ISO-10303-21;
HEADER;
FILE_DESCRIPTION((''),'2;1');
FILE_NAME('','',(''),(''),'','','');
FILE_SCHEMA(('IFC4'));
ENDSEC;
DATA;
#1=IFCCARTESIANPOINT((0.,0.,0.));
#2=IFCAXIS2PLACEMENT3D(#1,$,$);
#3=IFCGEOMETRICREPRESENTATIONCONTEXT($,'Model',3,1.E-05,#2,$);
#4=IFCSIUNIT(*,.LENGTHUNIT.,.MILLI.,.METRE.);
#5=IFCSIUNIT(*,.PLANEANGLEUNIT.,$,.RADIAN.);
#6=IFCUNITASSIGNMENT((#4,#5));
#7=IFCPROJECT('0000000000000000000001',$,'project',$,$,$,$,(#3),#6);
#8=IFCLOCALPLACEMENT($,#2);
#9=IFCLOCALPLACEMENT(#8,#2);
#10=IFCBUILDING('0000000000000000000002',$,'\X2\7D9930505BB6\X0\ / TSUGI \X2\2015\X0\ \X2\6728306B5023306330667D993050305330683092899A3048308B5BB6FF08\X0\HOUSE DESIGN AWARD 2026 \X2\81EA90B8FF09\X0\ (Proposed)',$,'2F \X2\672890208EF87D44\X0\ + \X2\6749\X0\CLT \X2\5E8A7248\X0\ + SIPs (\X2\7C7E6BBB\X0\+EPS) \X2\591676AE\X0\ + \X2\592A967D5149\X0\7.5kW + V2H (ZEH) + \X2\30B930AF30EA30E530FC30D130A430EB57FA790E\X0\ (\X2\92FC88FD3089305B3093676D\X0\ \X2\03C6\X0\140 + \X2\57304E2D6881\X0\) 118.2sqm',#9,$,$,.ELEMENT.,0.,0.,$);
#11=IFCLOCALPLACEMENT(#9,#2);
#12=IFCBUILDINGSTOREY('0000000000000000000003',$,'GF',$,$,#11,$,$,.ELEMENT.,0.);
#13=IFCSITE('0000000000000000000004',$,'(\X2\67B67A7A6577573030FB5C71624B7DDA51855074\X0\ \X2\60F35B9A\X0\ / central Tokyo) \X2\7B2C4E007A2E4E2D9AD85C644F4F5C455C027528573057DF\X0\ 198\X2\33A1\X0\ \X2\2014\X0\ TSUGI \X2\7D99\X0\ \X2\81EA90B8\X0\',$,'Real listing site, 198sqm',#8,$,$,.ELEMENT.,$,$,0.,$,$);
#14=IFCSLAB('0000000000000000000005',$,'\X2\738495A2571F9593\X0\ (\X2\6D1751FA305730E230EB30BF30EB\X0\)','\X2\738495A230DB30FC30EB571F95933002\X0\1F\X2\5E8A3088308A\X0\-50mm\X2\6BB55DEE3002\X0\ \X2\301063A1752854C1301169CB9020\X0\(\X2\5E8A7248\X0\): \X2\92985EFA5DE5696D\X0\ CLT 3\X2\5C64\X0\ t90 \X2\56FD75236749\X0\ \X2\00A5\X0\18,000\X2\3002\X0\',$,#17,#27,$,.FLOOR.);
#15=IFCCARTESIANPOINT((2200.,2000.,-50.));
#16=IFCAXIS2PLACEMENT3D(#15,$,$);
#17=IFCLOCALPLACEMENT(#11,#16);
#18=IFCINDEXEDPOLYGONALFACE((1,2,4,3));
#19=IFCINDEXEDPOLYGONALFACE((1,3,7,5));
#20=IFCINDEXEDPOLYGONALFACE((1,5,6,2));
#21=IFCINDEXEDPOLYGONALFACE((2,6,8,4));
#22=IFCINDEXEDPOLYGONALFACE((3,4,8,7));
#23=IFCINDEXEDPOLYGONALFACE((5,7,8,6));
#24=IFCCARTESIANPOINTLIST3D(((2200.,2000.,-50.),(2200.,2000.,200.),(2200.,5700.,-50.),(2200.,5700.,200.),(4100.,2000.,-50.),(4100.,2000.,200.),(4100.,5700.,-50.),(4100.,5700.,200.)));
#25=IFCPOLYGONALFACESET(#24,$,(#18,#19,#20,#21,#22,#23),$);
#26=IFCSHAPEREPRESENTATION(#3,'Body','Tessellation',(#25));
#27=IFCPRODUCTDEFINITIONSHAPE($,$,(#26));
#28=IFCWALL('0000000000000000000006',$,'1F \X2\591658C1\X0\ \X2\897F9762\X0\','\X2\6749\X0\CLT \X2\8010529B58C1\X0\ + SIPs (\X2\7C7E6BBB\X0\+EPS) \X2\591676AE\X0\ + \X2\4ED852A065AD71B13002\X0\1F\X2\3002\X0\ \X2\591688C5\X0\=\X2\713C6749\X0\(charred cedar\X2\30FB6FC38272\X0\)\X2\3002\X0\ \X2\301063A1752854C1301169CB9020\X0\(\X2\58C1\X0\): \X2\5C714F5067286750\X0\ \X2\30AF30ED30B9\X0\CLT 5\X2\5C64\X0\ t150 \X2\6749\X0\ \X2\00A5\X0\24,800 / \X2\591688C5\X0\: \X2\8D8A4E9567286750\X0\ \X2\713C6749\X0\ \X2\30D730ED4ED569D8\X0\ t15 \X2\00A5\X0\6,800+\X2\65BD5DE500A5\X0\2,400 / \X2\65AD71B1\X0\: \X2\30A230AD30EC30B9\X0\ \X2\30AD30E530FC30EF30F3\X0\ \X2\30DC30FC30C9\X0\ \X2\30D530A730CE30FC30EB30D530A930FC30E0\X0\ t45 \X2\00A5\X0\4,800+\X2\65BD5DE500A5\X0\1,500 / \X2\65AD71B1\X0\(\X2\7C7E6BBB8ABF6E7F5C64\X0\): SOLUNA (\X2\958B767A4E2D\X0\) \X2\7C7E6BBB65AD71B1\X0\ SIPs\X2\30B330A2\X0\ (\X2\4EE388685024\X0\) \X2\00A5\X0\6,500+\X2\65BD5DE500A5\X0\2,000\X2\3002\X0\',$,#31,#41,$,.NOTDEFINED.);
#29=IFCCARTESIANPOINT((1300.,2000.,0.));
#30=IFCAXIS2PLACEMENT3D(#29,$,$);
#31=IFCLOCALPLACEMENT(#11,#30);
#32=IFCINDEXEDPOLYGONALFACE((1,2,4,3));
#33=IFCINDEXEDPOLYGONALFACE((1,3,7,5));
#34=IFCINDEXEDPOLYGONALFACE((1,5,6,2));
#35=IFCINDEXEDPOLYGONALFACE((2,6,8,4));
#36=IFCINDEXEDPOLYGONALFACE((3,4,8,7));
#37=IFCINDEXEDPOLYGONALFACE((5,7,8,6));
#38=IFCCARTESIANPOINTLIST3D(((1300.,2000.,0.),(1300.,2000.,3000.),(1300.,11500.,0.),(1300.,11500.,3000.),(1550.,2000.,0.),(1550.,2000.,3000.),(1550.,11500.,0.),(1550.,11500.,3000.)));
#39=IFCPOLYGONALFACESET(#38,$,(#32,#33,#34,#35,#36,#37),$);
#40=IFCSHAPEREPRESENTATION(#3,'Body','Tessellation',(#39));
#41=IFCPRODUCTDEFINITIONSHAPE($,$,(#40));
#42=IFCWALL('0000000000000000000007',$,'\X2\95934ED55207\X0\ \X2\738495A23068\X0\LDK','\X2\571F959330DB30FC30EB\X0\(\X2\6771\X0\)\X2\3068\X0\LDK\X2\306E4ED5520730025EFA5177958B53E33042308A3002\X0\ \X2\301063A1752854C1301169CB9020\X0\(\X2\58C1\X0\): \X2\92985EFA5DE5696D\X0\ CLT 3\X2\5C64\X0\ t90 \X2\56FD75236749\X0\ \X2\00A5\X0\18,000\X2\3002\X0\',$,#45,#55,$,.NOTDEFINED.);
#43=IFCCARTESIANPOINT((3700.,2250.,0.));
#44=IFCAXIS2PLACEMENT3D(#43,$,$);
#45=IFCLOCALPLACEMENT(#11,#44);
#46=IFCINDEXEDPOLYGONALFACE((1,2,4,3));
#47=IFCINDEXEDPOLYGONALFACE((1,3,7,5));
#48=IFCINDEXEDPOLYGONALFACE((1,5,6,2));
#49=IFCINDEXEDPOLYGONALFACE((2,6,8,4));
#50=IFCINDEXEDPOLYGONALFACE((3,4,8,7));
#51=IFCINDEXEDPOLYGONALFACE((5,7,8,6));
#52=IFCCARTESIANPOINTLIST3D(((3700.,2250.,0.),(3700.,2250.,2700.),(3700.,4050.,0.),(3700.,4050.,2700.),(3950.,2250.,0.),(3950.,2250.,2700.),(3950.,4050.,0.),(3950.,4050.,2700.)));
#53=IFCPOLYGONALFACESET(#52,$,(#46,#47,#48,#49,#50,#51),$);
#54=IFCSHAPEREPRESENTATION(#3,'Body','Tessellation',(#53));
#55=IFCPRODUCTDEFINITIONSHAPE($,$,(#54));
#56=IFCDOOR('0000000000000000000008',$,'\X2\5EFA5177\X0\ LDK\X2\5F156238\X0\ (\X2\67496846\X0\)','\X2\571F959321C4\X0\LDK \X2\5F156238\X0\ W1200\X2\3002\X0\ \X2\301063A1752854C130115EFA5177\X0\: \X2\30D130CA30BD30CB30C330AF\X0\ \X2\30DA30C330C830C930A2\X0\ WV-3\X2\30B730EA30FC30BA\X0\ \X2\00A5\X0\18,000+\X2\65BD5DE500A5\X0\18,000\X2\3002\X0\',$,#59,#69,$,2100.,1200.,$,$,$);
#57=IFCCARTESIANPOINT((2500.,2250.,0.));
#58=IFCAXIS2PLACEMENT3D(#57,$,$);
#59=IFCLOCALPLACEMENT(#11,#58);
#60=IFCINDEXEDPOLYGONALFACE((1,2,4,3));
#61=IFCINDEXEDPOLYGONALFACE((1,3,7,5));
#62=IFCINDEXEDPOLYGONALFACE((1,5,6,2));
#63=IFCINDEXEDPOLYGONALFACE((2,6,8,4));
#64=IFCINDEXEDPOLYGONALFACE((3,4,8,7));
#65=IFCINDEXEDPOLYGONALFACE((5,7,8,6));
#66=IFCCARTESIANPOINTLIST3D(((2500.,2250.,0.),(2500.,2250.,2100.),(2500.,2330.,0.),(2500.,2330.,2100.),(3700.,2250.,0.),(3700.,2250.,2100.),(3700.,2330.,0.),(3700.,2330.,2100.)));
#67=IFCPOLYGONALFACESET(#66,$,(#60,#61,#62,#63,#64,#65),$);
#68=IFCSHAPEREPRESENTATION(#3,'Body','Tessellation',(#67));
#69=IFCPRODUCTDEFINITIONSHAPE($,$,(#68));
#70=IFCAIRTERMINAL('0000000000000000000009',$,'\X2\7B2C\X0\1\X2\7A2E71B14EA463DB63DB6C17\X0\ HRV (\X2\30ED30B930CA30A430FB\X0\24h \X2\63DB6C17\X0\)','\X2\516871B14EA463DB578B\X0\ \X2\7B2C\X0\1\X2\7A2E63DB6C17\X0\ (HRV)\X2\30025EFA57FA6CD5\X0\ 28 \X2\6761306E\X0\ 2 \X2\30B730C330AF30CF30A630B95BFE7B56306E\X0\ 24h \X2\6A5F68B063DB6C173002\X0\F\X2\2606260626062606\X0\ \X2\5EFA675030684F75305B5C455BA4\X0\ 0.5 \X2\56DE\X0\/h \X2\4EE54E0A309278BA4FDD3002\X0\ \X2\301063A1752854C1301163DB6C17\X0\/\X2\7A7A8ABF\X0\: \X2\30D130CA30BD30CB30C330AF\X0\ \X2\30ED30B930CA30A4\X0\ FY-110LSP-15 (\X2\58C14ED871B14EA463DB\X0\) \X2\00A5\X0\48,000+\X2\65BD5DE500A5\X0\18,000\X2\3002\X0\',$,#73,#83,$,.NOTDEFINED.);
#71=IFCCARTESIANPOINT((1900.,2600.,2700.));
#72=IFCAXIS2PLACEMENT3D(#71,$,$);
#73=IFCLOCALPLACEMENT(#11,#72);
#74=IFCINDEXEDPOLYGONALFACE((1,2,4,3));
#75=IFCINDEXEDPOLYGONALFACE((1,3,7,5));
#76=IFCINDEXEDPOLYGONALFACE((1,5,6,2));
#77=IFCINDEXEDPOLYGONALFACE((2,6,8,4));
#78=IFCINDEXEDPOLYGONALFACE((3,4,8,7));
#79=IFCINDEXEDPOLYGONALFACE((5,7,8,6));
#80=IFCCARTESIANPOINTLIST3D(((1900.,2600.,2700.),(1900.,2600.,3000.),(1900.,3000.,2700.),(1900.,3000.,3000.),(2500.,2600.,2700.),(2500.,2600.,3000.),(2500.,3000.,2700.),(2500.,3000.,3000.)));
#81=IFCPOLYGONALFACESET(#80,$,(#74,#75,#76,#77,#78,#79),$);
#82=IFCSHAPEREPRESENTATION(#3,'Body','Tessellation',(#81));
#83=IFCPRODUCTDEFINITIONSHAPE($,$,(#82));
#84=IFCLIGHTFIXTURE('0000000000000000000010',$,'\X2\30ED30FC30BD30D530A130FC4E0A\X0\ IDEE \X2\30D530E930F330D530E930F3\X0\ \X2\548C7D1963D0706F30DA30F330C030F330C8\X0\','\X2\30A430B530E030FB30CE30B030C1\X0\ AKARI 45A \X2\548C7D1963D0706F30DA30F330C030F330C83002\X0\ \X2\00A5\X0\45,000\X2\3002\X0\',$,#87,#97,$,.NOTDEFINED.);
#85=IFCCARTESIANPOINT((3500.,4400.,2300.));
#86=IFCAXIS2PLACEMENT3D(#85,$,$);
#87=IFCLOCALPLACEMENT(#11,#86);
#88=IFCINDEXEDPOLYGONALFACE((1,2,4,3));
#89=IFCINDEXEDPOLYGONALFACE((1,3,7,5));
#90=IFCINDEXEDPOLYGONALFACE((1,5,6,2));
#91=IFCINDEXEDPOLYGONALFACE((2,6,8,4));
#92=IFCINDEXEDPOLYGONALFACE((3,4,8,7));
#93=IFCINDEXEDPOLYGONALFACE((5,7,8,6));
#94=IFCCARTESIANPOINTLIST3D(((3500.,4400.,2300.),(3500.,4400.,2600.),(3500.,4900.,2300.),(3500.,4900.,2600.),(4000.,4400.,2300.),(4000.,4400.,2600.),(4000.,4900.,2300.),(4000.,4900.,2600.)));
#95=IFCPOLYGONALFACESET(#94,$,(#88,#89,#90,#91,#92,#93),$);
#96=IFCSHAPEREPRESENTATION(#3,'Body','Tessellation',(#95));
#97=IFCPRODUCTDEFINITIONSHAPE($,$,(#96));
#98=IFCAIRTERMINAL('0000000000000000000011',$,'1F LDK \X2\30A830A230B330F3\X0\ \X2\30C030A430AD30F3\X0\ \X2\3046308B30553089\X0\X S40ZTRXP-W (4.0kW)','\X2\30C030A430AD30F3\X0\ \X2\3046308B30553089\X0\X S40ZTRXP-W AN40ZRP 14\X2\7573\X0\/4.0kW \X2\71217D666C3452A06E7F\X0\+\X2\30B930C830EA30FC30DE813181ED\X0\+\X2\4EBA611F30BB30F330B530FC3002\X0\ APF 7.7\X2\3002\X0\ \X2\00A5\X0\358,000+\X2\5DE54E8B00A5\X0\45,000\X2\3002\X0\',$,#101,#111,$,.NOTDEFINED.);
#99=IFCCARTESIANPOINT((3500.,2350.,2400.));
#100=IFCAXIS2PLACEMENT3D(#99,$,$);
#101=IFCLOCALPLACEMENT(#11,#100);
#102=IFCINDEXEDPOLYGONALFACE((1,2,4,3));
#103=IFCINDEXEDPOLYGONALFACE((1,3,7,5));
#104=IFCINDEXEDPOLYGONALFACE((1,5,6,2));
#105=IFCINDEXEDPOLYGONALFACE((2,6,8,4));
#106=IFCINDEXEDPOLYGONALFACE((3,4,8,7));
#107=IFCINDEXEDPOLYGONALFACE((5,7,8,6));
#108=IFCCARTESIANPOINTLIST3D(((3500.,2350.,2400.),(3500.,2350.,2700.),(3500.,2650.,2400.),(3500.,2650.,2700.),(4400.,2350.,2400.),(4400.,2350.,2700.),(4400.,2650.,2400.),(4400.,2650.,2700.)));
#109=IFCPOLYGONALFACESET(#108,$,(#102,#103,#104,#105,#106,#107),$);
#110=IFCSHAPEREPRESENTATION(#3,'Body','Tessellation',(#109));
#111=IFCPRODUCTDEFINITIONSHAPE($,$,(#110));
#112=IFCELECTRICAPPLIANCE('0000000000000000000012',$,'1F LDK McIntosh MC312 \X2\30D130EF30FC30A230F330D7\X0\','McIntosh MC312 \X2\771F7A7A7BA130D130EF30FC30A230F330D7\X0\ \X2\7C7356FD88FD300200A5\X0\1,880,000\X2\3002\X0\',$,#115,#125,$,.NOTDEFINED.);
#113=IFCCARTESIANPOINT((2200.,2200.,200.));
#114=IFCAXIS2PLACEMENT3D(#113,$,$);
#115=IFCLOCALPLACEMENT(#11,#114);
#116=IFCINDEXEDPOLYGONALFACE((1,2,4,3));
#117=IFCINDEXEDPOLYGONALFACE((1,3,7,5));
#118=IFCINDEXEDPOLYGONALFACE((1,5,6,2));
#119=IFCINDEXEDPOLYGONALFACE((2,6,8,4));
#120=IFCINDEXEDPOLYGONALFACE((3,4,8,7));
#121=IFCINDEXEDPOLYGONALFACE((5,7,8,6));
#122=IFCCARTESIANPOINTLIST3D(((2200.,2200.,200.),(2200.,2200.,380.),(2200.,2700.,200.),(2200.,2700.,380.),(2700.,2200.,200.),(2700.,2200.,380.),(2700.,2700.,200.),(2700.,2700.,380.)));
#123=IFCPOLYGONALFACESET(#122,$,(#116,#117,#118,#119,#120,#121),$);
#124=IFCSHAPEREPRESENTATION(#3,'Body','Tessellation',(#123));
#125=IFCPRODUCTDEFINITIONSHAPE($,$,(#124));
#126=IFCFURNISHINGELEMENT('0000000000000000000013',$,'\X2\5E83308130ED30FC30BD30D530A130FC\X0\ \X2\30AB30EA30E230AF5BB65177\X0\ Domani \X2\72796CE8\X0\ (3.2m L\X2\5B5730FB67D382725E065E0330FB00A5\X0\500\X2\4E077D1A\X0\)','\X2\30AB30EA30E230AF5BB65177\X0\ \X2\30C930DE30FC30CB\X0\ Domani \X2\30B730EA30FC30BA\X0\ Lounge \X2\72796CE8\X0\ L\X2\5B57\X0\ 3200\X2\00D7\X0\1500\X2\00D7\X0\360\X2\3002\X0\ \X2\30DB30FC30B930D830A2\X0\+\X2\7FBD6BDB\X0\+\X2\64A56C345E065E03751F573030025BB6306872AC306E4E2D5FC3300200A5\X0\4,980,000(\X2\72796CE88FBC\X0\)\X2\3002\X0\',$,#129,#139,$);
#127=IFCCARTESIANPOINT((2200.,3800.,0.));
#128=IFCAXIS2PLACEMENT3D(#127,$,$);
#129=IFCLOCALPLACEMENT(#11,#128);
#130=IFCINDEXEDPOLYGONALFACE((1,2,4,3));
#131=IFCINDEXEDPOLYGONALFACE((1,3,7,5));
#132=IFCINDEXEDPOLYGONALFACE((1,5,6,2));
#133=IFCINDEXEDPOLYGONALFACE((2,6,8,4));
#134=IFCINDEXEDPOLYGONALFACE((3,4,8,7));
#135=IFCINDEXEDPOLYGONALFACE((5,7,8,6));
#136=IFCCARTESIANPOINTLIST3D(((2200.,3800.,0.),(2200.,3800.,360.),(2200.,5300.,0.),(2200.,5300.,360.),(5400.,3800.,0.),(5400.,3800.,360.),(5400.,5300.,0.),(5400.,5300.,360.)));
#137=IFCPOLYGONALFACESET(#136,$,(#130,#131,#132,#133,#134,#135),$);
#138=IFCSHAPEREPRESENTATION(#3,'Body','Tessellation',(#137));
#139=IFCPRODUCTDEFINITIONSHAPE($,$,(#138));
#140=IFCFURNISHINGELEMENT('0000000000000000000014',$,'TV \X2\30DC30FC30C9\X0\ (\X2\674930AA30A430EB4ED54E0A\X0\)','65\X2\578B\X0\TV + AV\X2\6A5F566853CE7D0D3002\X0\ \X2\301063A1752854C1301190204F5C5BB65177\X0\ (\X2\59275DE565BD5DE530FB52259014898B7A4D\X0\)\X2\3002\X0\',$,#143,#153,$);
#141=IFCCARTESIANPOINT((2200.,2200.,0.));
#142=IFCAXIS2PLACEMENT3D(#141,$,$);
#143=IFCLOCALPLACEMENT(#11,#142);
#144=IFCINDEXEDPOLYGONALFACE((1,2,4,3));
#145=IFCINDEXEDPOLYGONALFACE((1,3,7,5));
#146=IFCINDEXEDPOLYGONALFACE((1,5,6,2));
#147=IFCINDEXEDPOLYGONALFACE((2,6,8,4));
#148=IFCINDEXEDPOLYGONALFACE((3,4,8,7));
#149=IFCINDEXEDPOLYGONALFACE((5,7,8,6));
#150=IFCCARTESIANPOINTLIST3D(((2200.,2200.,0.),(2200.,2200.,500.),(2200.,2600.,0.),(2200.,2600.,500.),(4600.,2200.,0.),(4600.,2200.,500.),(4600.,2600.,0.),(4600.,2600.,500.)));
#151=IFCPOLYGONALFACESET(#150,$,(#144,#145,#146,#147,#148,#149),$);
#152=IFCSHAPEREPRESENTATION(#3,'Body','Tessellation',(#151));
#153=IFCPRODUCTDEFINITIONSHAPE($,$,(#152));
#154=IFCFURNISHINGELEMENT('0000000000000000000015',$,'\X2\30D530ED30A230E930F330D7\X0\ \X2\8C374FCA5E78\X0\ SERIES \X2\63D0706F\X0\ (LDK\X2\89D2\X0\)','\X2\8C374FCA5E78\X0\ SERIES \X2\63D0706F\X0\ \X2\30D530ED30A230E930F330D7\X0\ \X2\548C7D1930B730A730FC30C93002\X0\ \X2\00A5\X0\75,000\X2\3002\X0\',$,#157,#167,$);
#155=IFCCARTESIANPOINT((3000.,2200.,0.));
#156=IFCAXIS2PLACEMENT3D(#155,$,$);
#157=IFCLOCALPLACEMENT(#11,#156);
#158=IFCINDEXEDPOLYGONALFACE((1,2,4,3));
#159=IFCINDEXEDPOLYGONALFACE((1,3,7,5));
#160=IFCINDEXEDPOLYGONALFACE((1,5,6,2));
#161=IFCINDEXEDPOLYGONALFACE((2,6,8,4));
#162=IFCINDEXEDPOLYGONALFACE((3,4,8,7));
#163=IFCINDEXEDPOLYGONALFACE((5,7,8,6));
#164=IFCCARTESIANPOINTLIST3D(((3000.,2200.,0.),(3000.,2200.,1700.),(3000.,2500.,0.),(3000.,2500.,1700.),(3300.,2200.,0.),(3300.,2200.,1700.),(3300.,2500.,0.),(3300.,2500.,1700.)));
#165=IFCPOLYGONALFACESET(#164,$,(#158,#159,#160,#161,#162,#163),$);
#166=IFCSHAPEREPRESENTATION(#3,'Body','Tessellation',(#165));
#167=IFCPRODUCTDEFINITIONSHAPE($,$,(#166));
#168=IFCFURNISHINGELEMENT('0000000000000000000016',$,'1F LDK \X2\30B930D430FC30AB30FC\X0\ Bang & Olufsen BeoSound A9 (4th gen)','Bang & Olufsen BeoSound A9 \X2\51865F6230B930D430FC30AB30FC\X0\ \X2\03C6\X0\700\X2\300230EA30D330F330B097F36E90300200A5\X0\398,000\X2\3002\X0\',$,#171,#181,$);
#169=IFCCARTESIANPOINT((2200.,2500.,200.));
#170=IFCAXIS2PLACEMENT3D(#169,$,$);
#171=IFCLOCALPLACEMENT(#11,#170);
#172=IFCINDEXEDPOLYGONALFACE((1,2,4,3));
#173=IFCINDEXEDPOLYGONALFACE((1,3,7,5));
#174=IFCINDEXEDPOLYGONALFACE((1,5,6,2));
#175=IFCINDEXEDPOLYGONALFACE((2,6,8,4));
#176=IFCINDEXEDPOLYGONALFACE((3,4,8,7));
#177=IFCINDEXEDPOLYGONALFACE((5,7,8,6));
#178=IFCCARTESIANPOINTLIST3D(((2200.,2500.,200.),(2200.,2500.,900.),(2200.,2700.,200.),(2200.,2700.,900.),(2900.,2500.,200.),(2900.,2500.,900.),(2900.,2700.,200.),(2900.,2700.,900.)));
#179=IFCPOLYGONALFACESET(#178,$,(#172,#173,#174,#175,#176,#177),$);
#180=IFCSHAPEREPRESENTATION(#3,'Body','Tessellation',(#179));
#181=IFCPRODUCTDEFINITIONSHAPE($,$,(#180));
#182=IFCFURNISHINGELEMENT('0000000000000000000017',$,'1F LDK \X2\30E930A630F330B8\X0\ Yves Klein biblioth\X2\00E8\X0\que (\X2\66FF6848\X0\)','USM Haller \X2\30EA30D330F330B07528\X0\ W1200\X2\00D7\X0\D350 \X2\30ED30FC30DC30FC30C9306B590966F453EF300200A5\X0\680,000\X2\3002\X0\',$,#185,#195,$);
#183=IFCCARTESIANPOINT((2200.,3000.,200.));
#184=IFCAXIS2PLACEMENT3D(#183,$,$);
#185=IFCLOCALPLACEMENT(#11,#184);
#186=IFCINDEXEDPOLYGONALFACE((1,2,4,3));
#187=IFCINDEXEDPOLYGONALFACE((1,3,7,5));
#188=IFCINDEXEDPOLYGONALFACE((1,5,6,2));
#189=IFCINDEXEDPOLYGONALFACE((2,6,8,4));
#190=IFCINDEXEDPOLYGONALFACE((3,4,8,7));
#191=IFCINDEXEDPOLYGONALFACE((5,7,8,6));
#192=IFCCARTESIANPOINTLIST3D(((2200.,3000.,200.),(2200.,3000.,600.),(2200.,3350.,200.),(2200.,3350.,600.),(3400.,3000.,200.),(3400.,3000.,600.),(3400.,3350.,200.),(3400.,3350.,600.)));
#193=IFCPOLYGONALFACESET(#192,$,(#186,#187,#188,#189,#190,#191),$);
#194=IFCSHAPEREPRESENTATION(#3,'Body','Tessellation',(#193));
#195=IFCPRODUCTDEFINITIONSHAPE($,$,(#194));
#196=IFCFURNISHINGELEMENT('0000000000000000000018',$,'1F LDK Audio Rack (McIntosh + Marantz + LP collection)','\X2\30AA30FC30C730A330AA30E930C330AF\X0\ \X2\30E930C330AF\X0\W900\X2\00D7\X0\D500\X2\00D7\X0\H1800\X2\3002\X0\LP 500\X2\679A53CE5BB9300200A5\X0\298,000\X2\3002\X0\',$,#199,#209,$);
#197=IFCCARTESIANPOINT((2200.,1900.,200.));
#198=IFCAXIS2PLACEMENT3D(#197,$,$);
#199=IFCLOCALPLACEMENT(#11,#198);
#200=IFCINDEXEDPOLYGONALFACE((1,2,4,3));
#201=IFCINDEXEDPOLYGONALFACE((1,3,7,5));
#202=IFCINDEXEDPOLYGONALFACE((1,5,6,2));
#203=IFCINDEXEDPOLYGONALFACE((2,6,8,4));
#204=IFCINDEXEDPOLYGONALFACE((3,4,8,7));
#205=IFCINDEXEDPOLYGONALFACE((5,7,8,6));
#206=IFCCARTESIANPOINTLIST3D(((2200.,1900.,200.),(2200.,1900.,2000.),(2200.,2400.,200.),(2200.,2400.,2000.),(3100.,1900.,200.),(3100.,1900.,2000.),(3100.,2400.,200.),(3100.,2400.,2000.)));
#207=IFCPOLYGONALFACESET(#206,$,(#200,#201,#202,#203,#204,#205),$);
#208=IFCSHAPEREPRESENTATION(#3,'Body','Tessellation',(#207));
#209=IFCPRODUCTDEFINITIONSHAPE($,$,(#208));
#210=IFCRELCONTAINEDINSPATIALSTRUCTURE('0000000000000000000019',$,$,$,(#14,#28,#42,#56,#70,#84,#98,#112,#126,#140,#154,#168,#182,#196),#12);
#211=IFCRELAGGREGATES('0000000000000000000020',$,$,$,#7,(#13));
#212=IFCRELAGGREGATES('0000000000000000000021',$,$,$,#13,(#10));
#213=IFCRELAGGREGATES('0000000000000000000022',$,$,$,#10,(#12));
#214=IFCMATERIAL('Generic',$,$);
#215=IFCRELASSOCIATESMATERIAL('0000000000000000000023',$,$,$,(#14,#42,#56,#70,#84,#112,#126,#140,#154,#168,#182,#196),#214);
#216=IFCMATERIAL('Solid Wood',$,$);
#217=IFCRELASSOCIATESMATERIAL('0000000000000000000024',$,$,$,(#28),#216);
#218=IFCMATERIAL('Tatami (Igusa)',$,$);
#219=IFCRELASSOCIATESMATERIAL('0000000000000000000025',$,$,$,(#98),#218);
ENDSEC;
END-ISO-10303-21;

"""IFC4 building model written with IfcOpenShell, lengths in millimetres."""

from ifc_helpers import new_model, si_unit, frame, frame_2d, origin, place, context, project, spatial, rectangle, extrude, material, element, save


model = new_model("IFC4")

# Units and contexts
model_context = context("Model", 3, precision=1e-05, world=origin())
ifc_project = project(units=[si_unit("LENGTHUNIT", "METRE", prefix="MILLI"), si_unit("PLANEANGLEUNIT", "RADIAN")], contexts=[model_context])

# Site, building, storey
site_placement = place(None, origin())
site = spatial("IfcSite", under=ifc_project, at=site_placement, Name="(架空敷地・山手線内側 想定 / central Tokyo) 第一種中高層住居専用地域 198㎡ — TSUGI 継 自邸", ObjectType="Real listing site, 198sqm", CompositionType="ELEMENT", RefElevation=0.0)
building_placement = place(site_placement, origin())
building = spatial("IfcBuilding", under=site, at=building_placement, Name="継ぐ家 / TSUGI ― 木に倣って継ぐことを覚える家（HOUSE DESIGN AWARD 2026 自邸） (Proposed)", ObjectType="2F 木造軸組 + 杉CLT 床版 + SIPs (籾殻+EPS) 外皮 + 太陽光7.5kW + V2H (ZEH) + スクリューパイル基礎 (鋼製らせん杭 φ140 + 地中梁) 118.2sqm", CompositionType="ELEMENT", ElevationOfRefHeight=0.0, ElevationOfTerrain=0.0)
storey_placement = place(building_placement, origin())
storey = spatial("IfcBuildingStorey", under=building, at=storey_placement, Name="GF", CompositionType="ELEMENT", Elevation=0.0)

# Shared definitions
ifc_material_1 = material(Name="Generic")

# Slab
slab_1_placement = place(storey_placement, frame((2200.0, 2000.0, -50.0)))
element("IfcSlab", 1, at=slab_1_placement, inside=storey, material=ifc_material_1, Name="玄関土間 (洗出しモルタル)", Description="玄関ホール土間。1F床より-50mm段差。 【採用品】構造(床版): 銘建工業 CLT 3層 t90 国産杉 ¥18,000。", PredefinedType="FLOOR", context=model_context, shape_type="SweptSolid", body=[
    extrude(rectangle(XDim=1900.0, YDim=3700.0, at=frame_2d((950.0, 1850.0))), frame((2200.0, 2000.0, -50.0)), (0.0, 0.0, 1.0), 250.0),
])

# Shared definitions
ifc_material_2 = material(Name="Solid Wood")

# Walls
wall_1_placement = place(storey_placement, frame((1300.0, 2000.0, 0.0)))
element("IfcWall", 2, at=wall_1_placement, inside=storey, material=ifc_material_2, Name="1F 外壁 西面", Description="杉CLT 耐力壁 + SIPs (籾殻+EPS) 外皮 + 付加断熱。1F。 外装=焼杉(charred cedar・濃色)。 【採用品】構造(壁): 山佐木材 クロスCLT 5層 t150 杉 ¥24,800 / 外装: 越井木材 焼杉 プロ仕様 t15 ¥6,800+施工¥2,400 / 断熱: アキレス キューワン ボード フェノールフォーム t45 ¥4,800+施工¥1,500 / 断熱(籾殻調湿層): SOLUNA (開発中) 籾殻断熱 SIPsコア (代表値) ¥6,500+施工¥2,000。", PredefinedType="NOTDEFINED", context=model_context, shape_type="SweptSolid", body=[
    extrude(rectangle(XDim=250.0, YDim=9500.0, at=frame_2d((125.0, 4750.0))), frame((1300.0, 2000.0, 0.0)), (0.0, 0.0, 1.0), 3000.0),
])
wall_2_placement = place(storey_placement, frame((3700.0, 2250.0, 0.0)))
element("IfcWall", 3, at=wall_2_placement, inside=storey, material=ifc_material_1, Name="間仕切 玄関とLDK", Description="土間ホール(東)とLDKの仕切。建具開口あり。 【採用品】構造(壁): 銘建工業 CLT 3層 t90 国産杉 ¥18,000。", PredefinedType="NOTDEFINED", context=model_context, shape_type="SweptSolid", body=[
    extrude(rectangle(XDim=250.0, YDim=1800.0, at=frame_2d((125.0, 900.0))), frame((3700.0, 2250.0, 0.0)), (0.0, 0.0, 1.0), 2700.0),
])

# Door
door_placement = place(storey_placement, frame((2500.0, 2250.0, 0.0)))
element("IfcDoor", 4, at=door_placement, inside=storey, material=ifc_material_1, Name="建具 LDK引戸 (杉框)", Description="土間⇄LDK 引戸 W1200。 【採用品】建具: パナソニック ペットドア WV-3シリーズ ¥18,000+施工¥18,000。", OverallHeight=2100.0, OverallWidth=1200.0, context=model_context, shape_type="SweptSolid", body=[
    extrude(rectangle(XDim=1200.0, YDim=80.0, at=frame_2d((600.0, 40.0))), frame((2500.0, 2250.0, 0.0)), (0.0, 0.0, 1.0), 2100.0),
])

# Air terminal
air_terminal_1_placement = place(storey_placement, frame((1900.0, 2600.0, 2700.0)))
element("IfcAirTerminal", 5, at=air_terminal_1_placement, inside=storey, material=ifc_material_1, Name="第1種熱交換換気 HRV (ロスナイ・24h 換気)", Description="全熱交換型 第1種換気 (HRV)。建基法 28 条の 2 シックハウス対策の 24h 機械換気。F☆☆☆☆ 建材と併せ居室 0.5 回/h 以上を確保。 【採用品】換気/空調: パナソニック ロスナイ FY-110LSP-15 (壁付熱交換) ¥48,000+施工¥18,000。", PredefinedType="NOTDEFINED", context=model_context, shape_type="SweptSolid", body=[
    extrude(rectangle(XDim=600.0, YDim=400.0, at=frame_2d((300.0, 200.0))), frame((1900.0, 2600.0, 2700.0)), (0.0, 0.0, 1.0), 300.0),
])

# Light fixture
light_fixture_placement = place(storey_placement, frame((3500.0, 4400.0, 2300.0)))
element("IfcLightFixture", 6, at=light_fixture_placement, inside=storey, material=ifc_material_1, Name="ローソファー上 IDEE フランフラン 和紙提灯ペンダント", Description="イサム・ノグチ AKARI 45A 和紙提灯ペンダント。 ¥45,000。", PredefinedType="NOTDEFINED", context=model_context, shape_type="SweptSolid", body=[
    extrude(rectangle(XDim=500.0, YDim=500.0, at=frame_2d((250.0, 250.0))), frame((3500.0, 4400.0, 2300.0)), (0.0, 0.0, 1.0), 300.0),
])

# Air terminal
ifc_material_3 = material(Name="Tatami (Igusa)")
air_terminal_2_placement = place(storey_placement, frame((3500.0, 2350.0, 2400.0)))
element("IfcAirTerminal", 7, at=air_terminal_2_placement, inside=storey, material=ifc_material_3, Name="1F LDK エアコン ダイキン うるさらX S40ZTRXP-W (4.0kW)", Description="ダイキン うるさらX S40ZTRXP-W AN40ZRP 14畳/4.0kW 無給水加湿+ストリーマ脱臭+人感センサー。 APF 7.7。 ¥358,000+工事¥45,000。", PredefinedType="NOTDEFINED", context=model_context, shape_type="SweptSolid", body=[
    extrude(rectangle(XDim=900.0, YDim=300.0, at=frame_2d((450.0, 150.0))), frame((3500.0, 2350.0, 2400.0)), (0.0, 0.0, 1.0), 300.0),
])

# Electric appliance
electric_appliance_placement = place(storey_placement, frame((2200.0, 2200.0, 200.0)))
element("IfcElectricAppliance", 8, at=electric_appliance_placement, inside=storey, material=ifc_material_1, Name="1F LDK McIntosh MC312 パワーアンプ", Description="McIntosh MC312 真空管パワーアンプ 米国製。¥1,880,000。", PredefinedType="NOTDEFINED", context=model_context, shape_type="SweptSolid", body=[
    extrude(rectangle(XDim=500.0, YDim=500.0, at=frame_2d((250.0, 250.0))), frame((2200.0, 2200.0, 200.0)), (0.0, 0.0, 1.0), 180.0),
])

# Furnishing elements
furnishing_1_placement = place(storey_placement, frame((2200.0, 3800.0, 0.0)))
element("IfcFurnishingElement", 9, at=furnishing_1_placement, inside=storey, material=ifc_material_1, Name="広めローソファー カリモク家具 Domani 特注 (3.2m L字・染色帆布・¥500万級)", Description="カリモク家具 ドマーニ Domani シリーズ Lounge 特注 L字 3200×1500×360。 ホースヘア+羽毛+撥水帆布生地。家と犬の中心。¥4,980,000(特注込)。", context=model_context, shape_type="SweptSolid", body=[
    extrude(rectangle(XDim=3200.0, YDim=1500.0, at=frame_2d((1600.0, 750.0))), frame((2200.0, 3800.0, 0.0)), (0.0, 0.0, 1.0), 360.0),
])
furnishing_2_placement = place(storey_placement, frame((2200.0, 2200.0, 0.0)))
element("IfcFurnishingElement", 10, at=furnishing_2_placement, inside=storey, material=ifc_material_1, Name="TV ボード (杉オイル仕上)", Description="65型TV + AV機器収納。 【採用品】造作家具 (大工施工・別途見積)。", context=model_context, shape_type="SweptSolid", body=[
    extrude(rectangle(XDim=2400.0, YDim=400.0, at=frame_2d((1200.0, 200.0))), frame((2200.0, 2200.0, 0.0)), (0.0, 0.0, 1.0), 500.0),
])
furnishing_3_placement = place(storey_placement, frame((3000.0, 2200.0, 0.0)))
element("IfcFurnishingElement", 11, at=furnishing_3_placement, inside=storey, material=ifc_material_1, Name="フロアランプ 谷俊幸 SERIES 提灯 (LDK角)", Description="谷俊幸 SERIES 提灯 フロアランプ 和紙シェード。 ¥75,000。", context=model_context, shape_type="SweptSolid", body=[
    extrude(rectangle(XDim=300.0, YDim=300.0, at=frame_2d((150.0, 150.0))), frame((3000.0, 2200.0, 0.0)), (0.0, 0.0, 1.0), 1700.0),
])
furnishing_4_placement = place(storey_placement, frame((2200.0, 2500.0, 200.0)))
element("IfcFurnishingElement", 12, at=furnishing_4_placement, inside=storey, material=ifc_material_1, Name="1F LDK スピーカー Bang & Olufsen BeoSound A9 (4th gen)", Description="Bang & Olufsen BeoSound A9 円形スピーカー φ700。リビング音源。¥398,000。", context=model_context, shape_type="SweptSolid", body=[
    extrude(rectangle(XDim=700.0, YDim=200.0, at=frame_2d((350.0, 100.0))), frame((2200.0, 2500.0, 200.0)), (0.0, 0.0, 1.0), 700.0),
])
furnishing_5_placement = place(storey_placement, frame((2200.0, 3000.0, 200.0)))
element("IfcFurnishingElement", 13, at=furnishing_5_placement, inside=storey, material=ifc_material_1, Name="1F LDK ラウンジ Yves Klein bibliothèque (替案)", Description="USM Haller リビング用 W1200×D350 ローボードに変更可。¥680,000。", context=model_context, shape_type="SweptSolid", body=[
    extrude(rectangle(XDim=1200.0, YDim=350.0, at=frame_2d((600.0, 175.0))), frame((2200.0, 3000.0, 200.0)), (0.0, 0.0, 1.0), 400.0),
])
furnishing_6_placement = place(storey_placement, frame((2200.0, 1900.0, 200.0)))
element("IfcFurnishingElement", 14, at=furnishing_6_placement, inside=storey, material=ifc_material_1, Name="1F LDK Audio Rack (McIntosh + Marantz + LP collection)", Description="オーディオラック ラックW900×D500×H1800。LP 500枚収容。¥298,000。", context=model_context, shape_type="SweptSolid", body=[
    extrude(rectangle(XDim=900.0, YDim=500.0, at=frame_2d((450.0, 250.0))), frame((2200.0, 1900.0, 200.0)), (0.0, 0.0, 1.0), 1800.0),
])

save(model, "model.ifc")
